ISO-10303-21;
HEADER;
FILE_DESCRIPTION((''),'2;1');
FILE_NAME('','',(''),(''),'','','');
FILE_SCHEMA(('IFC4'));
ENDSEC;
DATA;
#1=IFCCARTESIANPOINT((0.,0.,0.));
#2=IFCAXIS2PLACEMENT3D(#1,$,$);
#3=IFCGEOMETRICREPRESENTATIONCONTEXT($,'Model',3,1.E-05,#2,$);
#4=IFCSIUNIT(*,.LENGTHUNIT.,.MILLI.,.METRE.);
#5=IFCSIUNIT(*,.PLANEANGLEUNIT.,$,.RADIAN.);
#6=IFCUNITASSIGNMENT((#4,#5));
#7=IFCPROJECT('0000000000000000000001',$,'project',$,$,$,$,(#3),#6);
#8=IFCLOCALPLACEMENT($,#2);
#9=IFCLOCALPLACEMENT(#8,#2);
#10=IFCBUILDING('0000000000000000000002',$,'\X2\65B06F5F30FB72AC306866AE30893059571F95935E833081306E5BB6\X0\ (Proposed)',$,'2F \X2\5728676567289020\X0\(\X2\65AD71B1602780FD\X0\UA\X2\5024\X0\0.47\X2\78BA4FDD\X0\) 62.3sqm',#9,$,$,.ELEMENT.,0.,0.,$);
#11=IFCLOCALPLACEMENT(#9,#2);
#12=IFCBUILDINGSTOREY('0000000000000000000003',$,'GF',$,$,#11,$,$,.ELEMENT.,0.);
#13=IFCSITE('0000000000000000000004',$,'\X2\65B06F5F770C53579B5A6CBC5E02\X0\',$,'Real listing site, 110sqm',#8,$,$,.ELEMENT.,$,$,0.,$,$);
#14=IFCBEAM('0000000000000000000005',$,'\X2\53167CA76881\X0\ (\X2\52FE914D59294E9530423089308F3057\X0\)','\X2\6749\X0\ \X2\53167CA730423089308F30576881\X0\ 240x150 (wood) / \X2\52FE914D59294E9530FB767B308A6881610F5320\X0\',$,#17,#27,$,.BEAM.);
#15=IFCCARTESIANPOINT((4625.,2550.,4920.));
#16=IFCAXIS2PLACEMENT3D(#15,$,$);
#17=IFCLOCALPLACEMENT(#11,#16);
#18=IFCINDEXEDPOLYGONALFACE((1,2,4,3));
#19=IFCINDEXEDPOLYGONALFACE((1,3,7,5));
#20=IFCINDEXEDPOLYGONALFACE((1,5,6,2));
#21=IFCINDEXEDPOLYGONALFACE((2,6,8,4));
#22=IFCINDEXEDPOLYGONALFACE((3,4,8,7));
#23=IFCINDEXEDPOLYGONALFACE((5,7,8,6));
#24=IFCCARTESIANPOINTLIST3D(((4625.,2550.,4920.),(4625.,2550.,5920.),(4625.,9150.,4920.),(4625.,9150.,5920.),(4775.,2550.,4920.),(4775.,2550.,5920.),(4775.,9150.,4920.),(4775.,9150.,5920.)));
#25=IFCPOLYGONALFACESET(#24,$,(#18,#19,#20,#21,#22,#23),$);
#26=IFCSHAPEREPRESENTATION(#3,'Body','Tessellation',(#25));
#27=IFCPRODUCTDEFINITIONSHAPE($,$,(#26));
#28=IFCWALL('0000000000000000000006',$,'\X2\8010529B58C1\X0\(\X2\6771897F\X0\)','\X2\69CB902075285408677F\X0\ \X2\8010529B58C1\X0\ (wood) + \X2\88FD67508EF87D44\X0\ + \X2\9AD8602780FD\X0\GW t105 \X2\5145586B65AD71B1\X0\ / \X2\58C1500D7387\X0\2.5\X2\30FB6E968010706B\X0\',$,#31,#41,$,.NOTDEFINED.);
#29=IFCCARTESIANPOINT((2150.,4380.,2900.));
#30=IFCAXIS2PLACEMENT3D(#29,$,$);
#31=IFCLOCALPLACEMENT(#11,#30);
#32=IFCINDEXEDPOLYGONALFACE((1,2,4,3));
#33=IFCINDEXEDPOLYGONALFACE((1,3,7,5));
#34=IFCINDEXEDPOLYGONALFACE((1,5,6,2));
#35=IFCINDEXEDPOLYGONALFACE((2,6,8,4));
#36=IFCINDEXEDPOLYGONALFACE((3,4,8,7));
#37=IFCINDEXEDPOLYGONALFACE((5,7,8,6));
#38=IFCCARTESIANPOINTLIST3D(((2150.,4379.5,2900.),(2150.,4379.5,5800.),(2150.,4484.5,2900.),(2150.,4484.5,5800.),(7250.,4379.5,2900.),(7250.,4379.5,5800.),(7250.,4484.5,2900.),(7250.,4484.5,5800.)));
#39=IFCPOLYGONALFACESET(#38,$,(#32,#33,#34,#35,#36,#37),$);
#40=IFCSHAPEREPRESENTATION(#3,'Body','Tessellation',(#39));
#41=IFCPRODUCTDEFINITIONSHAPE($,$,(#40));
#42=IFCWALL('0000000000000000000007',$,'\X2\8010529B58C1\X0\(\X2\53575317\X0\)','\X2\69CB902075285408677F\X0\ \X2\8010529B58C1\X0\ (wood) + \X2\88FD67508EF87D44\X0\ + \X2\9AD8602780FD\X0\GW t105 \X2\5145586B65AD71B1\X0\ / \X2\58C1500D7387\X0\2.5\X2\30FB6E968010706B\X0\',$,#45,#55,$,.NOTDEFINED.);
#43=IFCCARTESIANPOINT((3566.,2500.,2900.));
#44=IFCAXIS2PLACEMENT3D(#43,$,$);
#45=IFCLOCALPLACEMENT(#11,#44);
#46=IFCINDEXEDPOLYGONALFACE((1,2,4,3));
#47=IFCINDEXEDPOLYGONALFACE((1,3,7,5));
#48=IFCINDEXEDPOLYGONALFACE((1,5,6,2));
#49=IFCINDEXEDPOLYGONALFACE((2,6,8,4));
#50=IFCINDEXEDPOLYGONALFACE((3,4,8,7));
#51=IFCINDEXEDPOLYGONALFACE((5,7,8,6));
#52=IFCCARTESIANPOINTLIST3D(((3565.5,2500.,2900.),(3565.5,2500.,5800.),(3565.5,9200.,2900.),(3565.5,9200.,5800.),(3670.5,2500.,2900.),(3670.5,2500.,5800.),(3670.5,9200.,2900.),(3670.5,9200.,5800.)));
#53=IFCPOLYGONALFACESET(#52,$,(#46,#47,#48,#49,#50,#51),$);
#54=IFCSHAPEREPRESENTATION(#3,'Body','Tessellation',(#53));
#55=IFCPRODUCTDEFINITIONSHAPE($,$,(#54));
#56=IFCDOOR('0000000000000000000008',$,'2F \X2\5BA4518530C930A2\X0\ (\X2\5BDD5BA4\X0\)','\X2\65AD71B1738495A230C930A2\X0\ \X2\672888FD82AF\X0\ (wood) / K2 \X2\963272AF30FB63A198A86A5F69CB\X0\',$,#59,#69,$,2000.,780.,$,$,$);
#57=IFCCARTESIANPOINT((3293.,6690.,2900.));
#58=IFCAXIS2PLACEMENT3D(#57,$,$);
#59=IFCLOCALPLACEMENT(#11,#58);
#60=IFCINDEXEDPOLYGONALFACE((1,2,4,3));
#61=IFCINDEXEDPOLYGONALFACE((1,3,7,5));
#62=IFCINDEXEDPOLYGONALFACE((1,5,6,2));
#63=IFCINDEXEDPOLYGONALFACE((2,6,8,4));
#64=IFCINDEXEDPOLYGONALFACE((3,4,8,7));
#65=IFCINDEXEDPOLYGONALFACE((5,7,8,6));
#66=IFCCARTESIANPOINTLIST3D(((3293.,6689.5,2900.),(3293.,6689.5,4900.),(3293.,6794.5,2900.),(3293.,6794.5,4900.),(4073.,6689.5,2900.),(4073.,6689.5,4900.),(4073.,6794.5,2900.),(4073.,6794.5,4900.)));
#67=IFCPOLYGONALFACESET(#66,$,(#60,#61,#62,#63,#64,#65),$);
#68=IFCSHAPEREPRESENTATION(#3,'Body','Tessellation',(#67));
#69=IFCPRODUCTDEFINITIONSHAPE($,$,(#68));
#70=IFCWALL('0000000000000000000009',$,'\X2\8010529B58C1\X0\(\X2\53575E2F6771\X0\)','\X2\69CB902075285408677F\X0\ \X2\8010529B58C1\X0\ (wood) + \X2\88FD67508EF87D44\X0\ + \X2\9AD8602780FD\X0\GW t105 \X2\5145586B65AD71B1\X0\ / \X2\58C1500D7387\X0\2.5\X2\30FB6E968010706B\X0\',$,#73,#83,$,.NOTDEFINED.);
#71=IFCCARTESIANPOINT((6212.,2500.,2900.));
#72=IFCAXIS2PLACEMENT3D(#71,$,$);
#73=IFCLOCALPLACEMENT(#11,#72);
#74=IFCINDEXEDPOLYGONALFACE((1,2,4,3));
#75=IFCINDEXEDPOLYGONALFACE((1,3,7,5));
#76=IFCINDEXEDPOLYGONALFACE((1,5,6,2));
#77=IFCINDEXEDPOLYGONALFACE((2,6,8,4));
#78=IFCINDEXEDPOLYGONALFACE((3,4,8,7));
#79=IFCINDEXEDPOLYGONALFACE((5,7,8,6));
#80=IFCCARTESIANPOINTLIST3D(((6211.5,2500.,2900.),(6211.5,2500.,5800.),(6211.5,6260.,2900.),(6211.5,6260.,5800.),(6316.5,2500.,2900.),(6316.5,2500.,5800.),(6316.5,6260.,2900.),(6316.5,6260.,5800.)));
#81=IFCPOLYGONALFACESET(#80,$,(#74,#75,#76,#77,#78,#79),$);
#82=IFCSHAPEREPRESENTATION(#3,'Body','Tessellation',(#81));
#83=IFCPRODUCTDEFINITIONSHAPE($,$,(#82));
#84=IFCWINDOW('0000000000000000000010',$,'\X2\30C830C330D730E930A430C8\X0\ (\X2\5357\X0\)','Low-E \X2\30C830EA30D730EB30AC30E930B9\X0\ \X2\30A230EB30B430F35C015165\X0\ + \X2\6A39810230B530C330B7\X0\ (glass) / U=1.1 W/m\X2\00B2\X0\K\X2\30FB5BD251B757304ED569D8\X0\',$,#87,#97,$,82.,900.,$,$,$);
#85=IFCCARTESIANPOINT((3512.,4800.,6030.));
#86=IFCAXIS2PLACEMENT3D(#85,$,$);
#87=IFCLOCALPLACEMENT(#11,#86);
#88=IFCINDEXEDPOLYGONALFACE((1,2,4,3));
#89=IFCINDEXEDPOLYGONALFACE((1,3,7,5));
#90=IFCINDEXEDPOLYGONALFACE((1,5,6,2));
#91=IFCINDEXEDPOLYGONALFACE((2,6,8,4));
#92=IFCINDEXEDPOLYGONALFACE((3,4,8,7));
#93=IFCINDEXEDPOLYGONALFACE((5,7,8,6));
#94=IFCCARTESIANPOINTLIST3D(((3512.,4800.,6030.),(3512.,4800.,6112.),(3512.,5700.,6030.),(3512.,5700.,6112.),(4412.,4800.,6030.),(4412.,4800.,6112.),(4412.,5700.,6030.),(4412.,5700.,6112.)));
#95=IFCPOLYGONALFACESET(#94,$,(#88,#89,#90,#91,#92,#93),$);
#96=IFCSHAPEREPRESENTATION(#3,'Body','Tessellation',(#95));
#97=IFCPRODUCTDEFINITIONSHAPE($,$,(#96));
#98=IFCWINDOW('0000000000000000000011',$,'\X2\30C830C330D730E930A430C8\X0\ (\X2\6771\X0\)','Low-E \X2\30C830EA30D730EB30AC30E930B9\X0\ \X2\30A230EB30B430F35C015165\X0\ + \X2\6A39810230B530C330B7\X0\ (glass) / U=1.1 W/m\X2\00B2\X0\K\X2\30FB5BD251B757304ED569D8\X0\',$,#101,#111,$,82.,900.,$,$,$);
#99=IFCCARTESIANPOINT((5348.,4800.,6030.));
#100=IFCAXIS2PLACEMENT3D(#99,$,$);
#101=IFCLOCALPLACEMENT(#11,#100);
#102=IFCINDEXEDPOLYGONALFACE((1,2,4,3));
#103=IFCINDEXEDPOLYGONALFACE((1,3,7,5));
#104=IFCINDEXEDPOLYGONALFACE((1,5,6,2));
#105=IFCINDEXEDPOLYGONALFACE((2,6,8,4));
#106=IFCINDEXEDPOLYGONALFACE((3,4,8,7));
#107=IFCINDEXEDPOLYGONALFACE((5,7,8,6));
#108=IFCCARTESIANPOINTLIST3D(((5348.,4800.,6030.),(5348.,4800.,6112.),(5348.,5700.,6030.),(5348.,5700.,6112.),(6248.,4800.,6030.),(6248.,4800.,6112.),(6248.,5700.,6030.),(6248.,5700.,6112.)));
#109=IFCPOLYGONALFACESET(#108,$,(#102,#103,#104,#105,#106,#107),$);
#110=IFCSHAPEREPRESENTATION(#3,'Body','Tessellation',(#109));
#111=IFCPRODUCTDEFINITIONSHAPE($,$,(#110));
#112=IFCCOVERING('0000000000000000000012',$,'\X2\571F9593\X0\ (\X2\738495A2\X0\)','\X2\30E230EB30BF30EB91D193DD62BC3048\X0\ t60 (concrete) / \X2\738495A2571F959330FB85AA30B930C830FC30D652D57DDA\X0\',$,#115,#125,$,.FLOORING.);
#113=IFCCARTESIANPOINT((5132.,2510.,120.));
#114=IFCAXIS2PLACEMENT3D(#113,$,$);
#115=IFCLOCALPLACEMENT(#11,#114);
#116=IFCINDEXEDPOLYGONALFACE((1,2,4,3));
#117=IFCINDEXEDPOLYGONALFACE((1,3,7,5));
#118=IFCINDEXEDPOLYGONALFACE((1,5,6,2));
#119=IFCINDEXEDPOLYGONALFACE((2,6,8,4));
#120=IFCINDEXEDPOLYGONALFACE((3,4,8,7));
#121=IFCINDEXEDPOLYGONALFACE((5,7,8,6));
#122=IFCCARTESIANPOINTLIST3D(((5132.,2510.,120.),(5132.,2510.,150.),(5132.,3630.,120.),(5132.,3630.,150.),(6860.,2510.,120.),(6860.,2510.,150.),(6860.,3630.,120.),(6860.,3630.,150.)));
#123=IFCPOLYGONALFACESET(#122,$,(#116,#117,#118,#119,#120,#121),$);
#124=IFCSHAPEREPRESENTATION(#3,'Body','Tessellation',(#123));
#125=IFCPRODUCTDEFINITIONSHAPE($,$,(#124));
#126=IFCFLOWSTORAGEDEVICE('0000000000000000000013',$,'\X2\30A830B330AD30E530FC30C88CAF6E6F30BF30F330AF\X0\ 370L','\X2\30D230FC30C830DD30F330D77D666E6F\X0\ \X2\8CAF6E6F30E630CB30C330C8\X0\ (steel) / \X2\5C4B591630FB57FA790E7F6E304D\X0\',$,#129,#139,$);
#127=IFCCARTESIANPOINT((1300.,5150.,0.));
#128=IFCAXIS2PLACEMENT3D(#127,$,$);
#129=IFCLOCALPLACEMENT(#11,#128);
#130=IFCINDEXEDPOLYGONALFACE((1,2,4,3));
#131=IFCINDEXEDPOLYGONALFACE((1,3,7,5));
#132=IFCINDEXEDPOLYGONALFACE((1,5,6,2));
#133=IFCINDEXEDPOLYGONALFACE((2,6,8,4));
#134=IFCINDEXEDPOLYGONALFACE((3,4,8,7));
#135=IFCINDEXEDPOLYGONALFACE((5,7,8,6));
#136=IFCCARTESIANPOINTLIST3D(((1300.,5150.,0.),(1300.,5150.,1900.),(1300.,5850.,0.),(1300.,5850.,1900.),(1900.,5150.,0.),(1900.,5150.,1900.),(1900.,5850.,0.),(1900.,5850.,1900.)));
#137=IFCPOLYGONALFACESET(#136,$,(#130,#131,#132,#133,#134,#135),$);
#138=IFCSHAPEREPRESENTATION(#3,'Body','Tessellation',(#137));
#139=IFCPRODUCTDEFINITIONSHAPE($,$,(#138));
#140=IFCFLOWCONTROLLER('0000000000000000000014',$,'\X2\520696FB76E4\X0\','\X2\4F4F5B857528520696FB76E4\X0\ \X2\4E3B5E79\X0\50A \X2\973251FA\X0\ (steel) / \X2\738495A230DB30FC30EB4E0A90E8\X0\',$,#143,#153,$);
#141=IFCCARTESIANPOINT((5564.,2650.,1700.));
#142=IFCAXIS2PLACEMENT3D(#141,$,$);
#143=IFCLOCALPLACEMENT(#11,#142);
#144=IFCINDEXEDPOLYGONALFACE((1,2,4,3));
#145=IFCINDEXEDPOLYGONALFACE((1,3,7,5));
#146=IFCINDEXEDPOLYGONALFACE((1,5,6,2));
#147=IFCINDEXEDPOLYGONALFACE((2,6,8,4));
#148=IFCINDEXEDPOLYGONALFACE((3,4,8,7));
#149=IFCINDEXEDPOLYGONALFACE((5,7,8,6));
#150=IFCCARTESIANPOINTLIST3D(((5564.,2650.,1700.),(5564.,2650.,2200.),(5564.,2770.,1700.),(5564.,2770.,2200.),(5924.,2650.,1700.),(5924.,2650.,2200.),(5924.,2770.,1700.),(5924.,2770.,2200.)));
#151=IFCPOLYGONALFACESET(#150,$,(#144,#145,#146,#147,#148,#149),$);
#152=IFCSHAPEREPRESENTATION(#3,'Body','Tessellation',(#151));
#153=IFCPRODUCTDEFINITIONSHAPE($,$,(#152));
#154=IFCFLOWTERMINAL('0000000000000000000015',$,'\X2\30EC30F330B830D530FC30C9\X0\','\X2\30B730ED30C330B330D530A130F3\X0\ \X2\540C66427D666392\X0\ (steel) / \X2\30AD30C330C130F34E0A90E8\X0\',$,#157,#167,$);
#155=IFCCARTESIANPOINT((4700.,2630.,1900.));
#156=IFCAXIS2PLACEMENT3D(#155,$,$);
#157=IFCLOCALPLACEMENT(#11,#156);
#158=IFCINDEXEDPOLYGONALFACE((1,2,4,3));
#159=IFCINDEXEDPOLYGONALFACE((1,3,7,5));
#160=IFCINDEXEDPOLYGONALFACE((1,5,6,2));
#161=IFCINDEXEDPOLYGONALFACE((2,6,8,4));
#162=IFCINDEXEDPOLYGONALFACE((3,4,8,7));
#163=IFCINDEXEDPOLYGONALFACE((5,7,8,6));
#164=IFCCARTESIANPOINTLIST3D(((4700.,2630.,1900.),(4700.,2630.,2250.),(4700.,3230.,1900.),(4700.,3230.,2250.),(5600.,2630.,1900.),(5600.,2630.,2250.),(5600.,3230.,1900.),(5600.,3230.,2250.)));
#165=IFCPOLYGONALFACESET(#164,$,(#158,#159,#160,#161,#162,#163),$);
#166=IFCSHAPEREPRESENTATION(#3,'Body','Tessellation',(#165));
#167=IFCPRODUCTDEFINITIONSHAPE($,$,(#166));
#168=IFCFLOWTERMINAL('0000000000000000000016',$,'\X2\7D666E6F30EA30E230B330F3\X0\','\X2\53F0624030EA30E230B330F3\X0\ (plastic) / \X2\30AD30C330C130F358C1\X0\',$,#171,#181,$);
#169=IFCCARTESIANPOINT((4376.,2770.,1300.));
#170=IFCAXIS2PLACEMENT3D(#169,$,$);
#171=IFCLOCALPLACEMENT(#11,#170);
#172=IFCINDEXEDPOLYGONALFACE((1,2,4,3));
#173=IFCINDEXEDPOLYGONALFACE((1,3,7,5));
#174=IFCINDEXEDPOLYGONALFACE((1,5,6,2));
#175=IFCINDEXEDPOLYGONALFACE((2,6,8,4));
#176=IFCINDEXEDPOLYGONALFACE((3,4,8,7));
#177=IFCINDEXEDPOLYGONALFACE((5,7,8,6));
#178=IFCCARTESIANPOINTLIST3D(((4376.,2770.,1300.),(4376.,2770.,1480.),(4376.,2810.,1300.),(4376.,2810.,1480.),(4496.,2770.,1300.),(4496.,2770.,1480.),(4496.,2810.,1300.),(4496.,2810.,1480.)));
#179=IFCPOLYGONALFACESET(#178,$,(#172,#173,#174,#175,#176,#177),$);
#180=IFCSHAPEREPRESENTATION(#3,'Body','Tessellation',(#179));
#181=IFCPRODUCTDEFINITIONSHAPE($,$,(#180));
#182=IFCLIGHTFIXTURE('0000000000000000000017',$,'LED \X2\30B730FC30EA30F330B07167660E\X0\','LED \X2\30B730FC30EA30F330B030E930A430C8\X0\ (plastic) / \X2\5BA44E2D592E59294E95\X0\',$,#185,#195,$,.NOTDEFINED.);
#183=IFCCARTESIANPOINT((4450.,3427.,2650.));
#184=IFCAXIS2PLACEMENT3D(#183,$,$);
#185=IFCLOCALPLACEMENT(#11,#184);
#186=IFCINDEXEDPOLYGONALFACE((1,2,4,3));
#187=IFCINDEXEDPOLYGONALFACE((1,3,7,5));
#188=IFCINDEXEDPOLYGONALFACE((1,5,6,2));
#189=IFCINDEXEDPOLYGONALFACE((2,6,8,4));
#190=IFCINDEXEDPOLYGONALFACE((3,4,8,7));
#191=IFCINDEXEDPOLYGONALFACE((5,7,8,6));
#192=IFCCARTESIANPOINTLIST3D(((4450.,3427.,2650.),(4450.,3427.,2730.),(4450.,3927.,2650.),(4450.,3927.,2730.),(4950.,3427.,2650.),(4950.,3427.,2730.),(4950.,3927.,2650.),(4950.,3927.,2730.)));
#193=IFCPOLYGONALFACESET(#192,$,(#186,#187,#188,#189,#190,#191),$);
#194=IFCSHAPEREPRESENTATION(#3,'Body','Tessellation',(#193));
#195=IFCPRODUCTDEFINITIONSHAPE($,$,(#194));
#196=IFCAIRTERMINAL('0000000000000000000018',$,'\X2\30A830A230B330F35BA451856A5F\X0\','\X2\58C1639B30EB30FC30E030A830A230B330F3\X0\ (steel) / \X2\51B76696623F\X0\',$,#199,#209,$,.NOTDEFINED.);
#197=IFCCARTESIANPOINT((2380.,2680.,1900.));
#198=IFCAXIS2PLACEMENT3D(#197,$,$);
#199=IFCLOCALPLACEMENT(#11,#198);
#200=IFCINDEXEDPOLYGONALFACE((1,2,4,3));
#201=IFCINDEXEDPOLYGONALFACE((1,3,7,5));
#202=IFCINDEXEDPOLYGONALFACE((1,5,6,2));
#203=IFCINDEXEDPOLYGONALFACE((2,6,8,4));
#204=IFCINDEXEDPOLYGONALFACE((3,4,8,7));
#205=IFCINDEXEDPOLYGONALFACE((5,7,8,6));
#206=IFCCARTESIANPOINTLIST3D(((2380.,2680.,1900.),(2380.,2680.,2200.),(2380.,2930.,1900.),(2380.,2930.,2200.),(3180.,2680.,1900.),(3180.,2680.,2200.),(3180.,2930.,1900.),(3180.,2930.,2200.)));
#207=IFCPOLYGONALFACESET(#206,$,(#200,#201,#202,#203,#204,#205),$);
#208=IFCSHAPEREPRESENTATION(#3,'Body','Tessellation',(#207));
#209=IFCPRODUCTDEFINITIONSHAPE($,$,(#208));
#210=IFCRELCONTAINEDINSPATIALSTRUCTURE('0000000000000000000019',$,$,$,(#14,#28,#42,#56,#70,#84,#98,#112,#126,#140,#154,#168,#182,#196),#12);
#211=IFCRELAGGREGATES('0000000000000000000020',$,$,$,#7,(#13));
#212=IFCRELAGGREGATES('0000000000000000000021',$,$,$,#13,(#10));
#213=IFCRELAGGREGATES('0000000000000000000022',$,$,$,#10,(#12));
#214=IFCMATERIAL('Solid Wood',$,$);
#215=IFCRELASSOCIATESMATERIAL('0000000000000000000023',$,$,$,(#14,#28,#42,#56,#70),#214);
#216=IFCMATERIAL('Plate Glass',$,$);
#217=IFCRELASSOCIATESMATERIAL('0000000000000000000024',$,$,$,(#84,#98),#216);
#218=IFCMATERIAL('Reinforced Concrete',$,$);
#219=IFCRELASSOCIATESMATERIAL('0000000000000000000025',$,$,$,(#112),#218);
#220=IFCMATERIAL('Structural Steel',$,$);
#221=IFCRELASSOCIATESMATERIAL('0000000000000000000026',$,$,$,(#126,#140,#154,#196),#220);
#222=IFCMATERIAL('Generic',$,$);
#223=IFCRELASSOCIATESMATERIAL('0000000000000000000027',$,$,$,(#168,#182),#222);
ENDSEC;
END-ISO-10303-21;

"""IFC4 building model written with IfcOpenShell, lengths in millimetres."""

from ifc_helpers import new_model, si_unit, frame, frame_2d, origin, place, context, project, spatial, rectangle, extrude, material, element, fill, save


model = new_model("IFC4")

# Units and contexts
model_context = context("Model", 3, precision=1e-05, world=origin())
ifc_project = project(units=[si_unit("LENGTHUNIT", "METRE", prefix="MILLI"), si_unit("PLANEANGLEUNIT", "RADIAN")], contexts=[model_context])

# Site, building, storey
site_placement = place(None, origin())
site = spatial("IfcSite", under=ifc_project, at=site_placement, Name="新潟県南魚沼市", ObjectType="Real listing site, 110sqm", CompositionType="ELEMENT", RefElevation=0.0)
building_placement = place(site_placement, origin())
building = spatial("IfcBuilding", under=site, at=building_placement, Name="新潟・犬と暮らす土間広めの家 (Proposed)", ObjectType="2F 在来木造(断熱性能UA値0.47確保) 62.3sqm", CompositionType="ELEMENT", ElevationOfRefHeight=0.0, ElevationOfTerrain=0.0)
storey_placement = place(building_placement, origin())
storey = spatial("IfcBuildingStorey", under=building, at=storey_placement, Name="GF", CompositionType="ELEMENT", Elevation=0.0)

# Shared definitions
ifc_material_1 = material(Name="Solid Wood")

# Beam
beam_placement = place(storey_placement, frame((4625.0, 2550.0, 4920.0)))
element("IfcBeam", 1, at=beam_placement, inside=storey, material=ifc_material_1, Name="化粧梁 (勾配天井あらわし)", Description="杉 化粧あらわし梁 240x150 (wood) / 勾配天井・登り梁意匠", PredefinedType="BEAM", context=model_context, shape_type="SweptSolid", body=[
    extrude(rectangle(XDim=150.0, YDim=6600.0, at=frame_2d((75.0, 3300.0))), frame((4625.0, 2550.0, 4920.0)), (0.0, 0.0, 1.0), 1000.0),
])

# Wall
wall_1_placement = place(storey_placement, frame((2150.0, 4380.0, 2900.0)))
element("IfcWall", 2, at=wall_1_placement, inside=storey, material=ifc_material_1, Name="耐力壁(東西)", Description="構造用合板 耐力壁 (wood) + 製材軸組 + 高性能GW t105 充填断熱 / 壁倍率2.5・準耐火", PredefinedType="NOTDEFINED", context=model_context, shape_type="SweptSolid", body=[
    extrude(rectangle(XDim=5100.0, YDim=105.0, at=frame_2d((2550.0, 52.0))), frame((2150.0, 4380.0, 2900.0)), (0.0, 0.0, 1.0), 2900.0),
])

# Wall, opening, door
wall_2_placement = place(storey_placement, frame((3566.0, 2500.0, 2900.0)))
wall_2 = element("IfcWall", 3, at=wall_2_placement, inside=storey, material=ifc_material_1, Name="耐力壁(南北)", Description="構造用合板 耐力壁 (wood) + 製材軸組 + 高性能GW t105 充填断熱 / 壁倍率2.5・準耐火", PredefinedType="NOTDEFINED", context=model_context, shape_type="SweptSolid", body=[
    extrude(rectangle(XDim=105.0, YDim=6700.0, at=frame_2d((52.0, 3350.0))), frame((3566.0, 2500.0, 2900.0)), (0.0, 0.0, 1.0), 2900.0),
])
opening_placement = place(storey_placement, frame((3293.0, 6690.0, 2900.0)))
opening = element("IfcOpeningElement", 4, at=opening_placement, cuts=wall_2, PredefinedType="NOTDEFINED", context=model_context, shape_type="SweptSolid", body=[
    extrude(rectangle(XDim=780.0, YDim=105.0, at=frame_2d((390.0, 52.0))), frame((3293.0, 6690.0, 2900.0)), (0.0, 0.0, 1.0), 2000.0),
])
door_placement = place(storey_placement, frame((3293.0, 6690.0, 2900.0)))
door = element("IfcDoor", 5, at=door_placement, inside=storey, material=ifc_material_1, Name="2F 室内ドア (寝室)", Description="断熱玄関ドア 木製芯 (wood) / K2 防犯・採風機構", OverallHeight=2000.0, OverallWidth=780.0, context=model_context, shape_type="SweptSolid", body=[
    extrude(rectangle(XDim=780.0, YDim=105.0, at=frame_2d((390.0, 52.0))), frame((3293.0, 6690.0, 2900.0)), (0.0, 0.0, 1.0), 2000.0),
])
fill(opening, door)

# Wall
wall_3_placement = place(storey_placement, frame((6212.0, 2500.0, 2900.0)))
element("IfcWall", 6, at=wall_3_placement, inside=storey, material=ifc_material_1, Name="耐力壁(南帯東)", Description="構造用合板 耐力壁 (wood) + 製材軸組 + 高性能GW t105 充填断熱 / 壁倍率2.5・準耐火", PredefinedType="NOTDEFINED", context=model_context, shape_type="SweptSolid", body=[
    extrude(rectangle(XDim=105.0, YDim=3760.0, at=frame_2d((52.0, 1880.0))), frame((6212.0, 2500.0, 2900.0)), (0.0, 0.0, 1.0), 2900.0),
])

# Windows
ifc_material_2 = material(Name="Plate Glass")
window_1_placement = place(storey_placement, frame((3512.0, 4800.0, 6030.0)))
element("IfcWindow", 7, at=window_1_placement, inside=storey, material=ifc_material_2, Name="トップライト (南)", Description="Low-E トリプルガラス アルゴン封入 + 樹脂サッシ (glass) / U=1.1 W/m²K・寒冷地仕様", OverallHeight=82.0, OverallWidth=900.0, context=model_context, shape_type="SweptSolid", body=[
    extrude(rectangle(XDim=900.0, YDim=900.0, at=frame_2d((450.0, 450.0))), frame((3512.0, 4800.0, 6030.0)), (0.0, 0.0, 1.0), 82.0),
])
window_2_placement = place(storey_placement, frame((5348.0, 4800.0, 6030.0)))
element("IfcWindow", 8, at=window_2_placement, inside=storey, material=ifc_material_2, Name="トップライト (東)", Description="Low-E トリプルガラス アルゴン封入 + 樹脂サッシ (glass) / U=1.1 W/m²K・寒冷地仕様", OverallHeight=82.0, OverallWidth=900.0, context=model_context, shape_type="SweptSolid", body=[
    extrude(rectangle(XDim=900.0, YDim=900.0, at=frame_2d((450.0, 450.0))), frame((5348.0, 4800.0, 6030.0)), (0.0, 0.0, 1.0), 82.0),
])

# Covering
ifc_material_3 = material(Name="Reinforced Concrete")
covering_placement = place(storey_placement, frame((5132.0, 2510.0, 120.0)))
element("IfcCovering", 9, at=covering_placement, inside=storey, material=ifc_material_3, Name="土間 (玄関)", Description="モルタル金鏝押え t60 (concrete) / 玄関土間・薪ストーブ動線", PredefinedType="FLOORING", context=model_context, shape_type="SweptSolid", body=[
    extrude(rectangle(XDim=1728.0, YDim=1120.0, at=frame_2d((864.0, 560.0))), frame((5132.0, 2510.0, 120.0)), (0.0, 0.0, 1.0), 30.0),
])

# Flow storage device
ifc_material_4 = material(Name="Structural Steel")
flow_storage_device_placement = place(storey_placement, frame((1300.0, 5150.0, 0.0)))
element("IfcFlowStorageDevice", 10, at=flow_storage_device_placement, inside=storey, material=ifc_material_4, Name="エコキュート貯湯タンク 370L", Description="ヒートポンプ給湯 貯湯ユニット (steel) / 屋外・基礎置き", context=model_context, shape_type="SweptSolid", body=[
    extrude(rectangle(XDim=600.0, YDim=700.0, at=frame_2d((300.0, 350.0))), frame((1300.0, 5150.0, 0.0)), (0.0, 0.0, 1.0), 1900.0),
])

# Flow controller
flow_controller_placement = place(storey_placement, frame((5564.0, 2650.0, 1700.0)))
element("IfcFlowController", 11, at=flow_controller_placement, inside=storey, material=ifc_material_4, Name="分電盤", Description="住宅用分電盤 主幹50A 露出 (steel) / 玄関ホール上部", context=model_context, shape_type="SweptSolid", body=[
    extrude(rectangle(XDim=360.0, YDim=120.0, at=frame_2d((180.0, 60.0))), frame((5564.0, 2650.0, 1700.0)), (0.0, 0.0, 1.0), 500.0),
])

# Flow terminals
flow_terminal_1_placement = place(storey_placement, frame((4700.0, 2630.0, 1900.0)))
element("IfcFlowTerminal", 12, at=flow_terminal_1_placement, inside=storey, material=ifc_material_4, Name="レンジフード", Description="シロッコファン 同時給排 (steel) / キッチン上部", context=model_context, shape_type="SweptSolid", body=[
    extrude(rectangle(XDim=900.0, YDim=600.0, at=frame_2d((450.0, 300.0))), frame((4700.0, 2630.0, 1900.0)), (0.0, 0.0, 1.0), 350.0),
])
ifc_material_5 = material(Name="Generic")
flow_terminal_2_placement = place(storey_placement, frame((4376.0, 2770.0, 1300.0)))
element("IfcFlowTerminal", 13, at=flow_terminal_2_placement, inside=storey, material=ifc_material_5, Name="給湯リモコン", Description="台所リモコン (plastic) / キッチン壁", context=model_context, shape_type="SweptSolid", body=[
    extrude(rectangle(XDim=120.0, YDim=40.0, at=frame_2d((60.0, 20.0))), frame((4376.0, 2770.0, 1300.0)), (0.0, 0.0, 1.0), 180.0),
])

# Light fixture
light_fixture_1_placement = place(storey_placement, frame((4450.0, 3427.0, 2650.0)))
element("IfcLightFixture", 14, at=light_fixture_1_placement, inside=storey, material=ifc_material_5, Name="LED シーリング照明", Description="LED シーリングライト (plastic) / 室中央天井", PredefinedType="NOTDEFINED", context=model_context, shape_type="SweptSolid", body=[
    extrude(rectangle(XDim=500.0, YDim=500.0, at=frame_2d((250.0, 250.0))), frame((4450.0, 3427.0, 2650.0)), (0.0, 0.0, 1.0), 80.0),
])

# Air terminal
air_terminal_1_placement = place(storey_placement, frame((2380.0, 2680.0, 1900.0)))
element("IfcAirTerminal", 15, at=air_terminal_1_placement, inside=storey, material=ifc_material_4, Name="エアコン室内機", Description="壁掛ルームエアコン (steel) / 冷暖房", PredefinedType="NOTDEFINED", context=model_context, shape_type="SweptSolid", body=[
    extrude(rectangle(XDim=800.0, YDim=250.0, at=frame_2d((400.0, 125.0))), frame((2380.0, 2680.0, 1900.0)), (0.0, 0.0, 1.0), 300.0),
])

save(model, "model.ifc")
